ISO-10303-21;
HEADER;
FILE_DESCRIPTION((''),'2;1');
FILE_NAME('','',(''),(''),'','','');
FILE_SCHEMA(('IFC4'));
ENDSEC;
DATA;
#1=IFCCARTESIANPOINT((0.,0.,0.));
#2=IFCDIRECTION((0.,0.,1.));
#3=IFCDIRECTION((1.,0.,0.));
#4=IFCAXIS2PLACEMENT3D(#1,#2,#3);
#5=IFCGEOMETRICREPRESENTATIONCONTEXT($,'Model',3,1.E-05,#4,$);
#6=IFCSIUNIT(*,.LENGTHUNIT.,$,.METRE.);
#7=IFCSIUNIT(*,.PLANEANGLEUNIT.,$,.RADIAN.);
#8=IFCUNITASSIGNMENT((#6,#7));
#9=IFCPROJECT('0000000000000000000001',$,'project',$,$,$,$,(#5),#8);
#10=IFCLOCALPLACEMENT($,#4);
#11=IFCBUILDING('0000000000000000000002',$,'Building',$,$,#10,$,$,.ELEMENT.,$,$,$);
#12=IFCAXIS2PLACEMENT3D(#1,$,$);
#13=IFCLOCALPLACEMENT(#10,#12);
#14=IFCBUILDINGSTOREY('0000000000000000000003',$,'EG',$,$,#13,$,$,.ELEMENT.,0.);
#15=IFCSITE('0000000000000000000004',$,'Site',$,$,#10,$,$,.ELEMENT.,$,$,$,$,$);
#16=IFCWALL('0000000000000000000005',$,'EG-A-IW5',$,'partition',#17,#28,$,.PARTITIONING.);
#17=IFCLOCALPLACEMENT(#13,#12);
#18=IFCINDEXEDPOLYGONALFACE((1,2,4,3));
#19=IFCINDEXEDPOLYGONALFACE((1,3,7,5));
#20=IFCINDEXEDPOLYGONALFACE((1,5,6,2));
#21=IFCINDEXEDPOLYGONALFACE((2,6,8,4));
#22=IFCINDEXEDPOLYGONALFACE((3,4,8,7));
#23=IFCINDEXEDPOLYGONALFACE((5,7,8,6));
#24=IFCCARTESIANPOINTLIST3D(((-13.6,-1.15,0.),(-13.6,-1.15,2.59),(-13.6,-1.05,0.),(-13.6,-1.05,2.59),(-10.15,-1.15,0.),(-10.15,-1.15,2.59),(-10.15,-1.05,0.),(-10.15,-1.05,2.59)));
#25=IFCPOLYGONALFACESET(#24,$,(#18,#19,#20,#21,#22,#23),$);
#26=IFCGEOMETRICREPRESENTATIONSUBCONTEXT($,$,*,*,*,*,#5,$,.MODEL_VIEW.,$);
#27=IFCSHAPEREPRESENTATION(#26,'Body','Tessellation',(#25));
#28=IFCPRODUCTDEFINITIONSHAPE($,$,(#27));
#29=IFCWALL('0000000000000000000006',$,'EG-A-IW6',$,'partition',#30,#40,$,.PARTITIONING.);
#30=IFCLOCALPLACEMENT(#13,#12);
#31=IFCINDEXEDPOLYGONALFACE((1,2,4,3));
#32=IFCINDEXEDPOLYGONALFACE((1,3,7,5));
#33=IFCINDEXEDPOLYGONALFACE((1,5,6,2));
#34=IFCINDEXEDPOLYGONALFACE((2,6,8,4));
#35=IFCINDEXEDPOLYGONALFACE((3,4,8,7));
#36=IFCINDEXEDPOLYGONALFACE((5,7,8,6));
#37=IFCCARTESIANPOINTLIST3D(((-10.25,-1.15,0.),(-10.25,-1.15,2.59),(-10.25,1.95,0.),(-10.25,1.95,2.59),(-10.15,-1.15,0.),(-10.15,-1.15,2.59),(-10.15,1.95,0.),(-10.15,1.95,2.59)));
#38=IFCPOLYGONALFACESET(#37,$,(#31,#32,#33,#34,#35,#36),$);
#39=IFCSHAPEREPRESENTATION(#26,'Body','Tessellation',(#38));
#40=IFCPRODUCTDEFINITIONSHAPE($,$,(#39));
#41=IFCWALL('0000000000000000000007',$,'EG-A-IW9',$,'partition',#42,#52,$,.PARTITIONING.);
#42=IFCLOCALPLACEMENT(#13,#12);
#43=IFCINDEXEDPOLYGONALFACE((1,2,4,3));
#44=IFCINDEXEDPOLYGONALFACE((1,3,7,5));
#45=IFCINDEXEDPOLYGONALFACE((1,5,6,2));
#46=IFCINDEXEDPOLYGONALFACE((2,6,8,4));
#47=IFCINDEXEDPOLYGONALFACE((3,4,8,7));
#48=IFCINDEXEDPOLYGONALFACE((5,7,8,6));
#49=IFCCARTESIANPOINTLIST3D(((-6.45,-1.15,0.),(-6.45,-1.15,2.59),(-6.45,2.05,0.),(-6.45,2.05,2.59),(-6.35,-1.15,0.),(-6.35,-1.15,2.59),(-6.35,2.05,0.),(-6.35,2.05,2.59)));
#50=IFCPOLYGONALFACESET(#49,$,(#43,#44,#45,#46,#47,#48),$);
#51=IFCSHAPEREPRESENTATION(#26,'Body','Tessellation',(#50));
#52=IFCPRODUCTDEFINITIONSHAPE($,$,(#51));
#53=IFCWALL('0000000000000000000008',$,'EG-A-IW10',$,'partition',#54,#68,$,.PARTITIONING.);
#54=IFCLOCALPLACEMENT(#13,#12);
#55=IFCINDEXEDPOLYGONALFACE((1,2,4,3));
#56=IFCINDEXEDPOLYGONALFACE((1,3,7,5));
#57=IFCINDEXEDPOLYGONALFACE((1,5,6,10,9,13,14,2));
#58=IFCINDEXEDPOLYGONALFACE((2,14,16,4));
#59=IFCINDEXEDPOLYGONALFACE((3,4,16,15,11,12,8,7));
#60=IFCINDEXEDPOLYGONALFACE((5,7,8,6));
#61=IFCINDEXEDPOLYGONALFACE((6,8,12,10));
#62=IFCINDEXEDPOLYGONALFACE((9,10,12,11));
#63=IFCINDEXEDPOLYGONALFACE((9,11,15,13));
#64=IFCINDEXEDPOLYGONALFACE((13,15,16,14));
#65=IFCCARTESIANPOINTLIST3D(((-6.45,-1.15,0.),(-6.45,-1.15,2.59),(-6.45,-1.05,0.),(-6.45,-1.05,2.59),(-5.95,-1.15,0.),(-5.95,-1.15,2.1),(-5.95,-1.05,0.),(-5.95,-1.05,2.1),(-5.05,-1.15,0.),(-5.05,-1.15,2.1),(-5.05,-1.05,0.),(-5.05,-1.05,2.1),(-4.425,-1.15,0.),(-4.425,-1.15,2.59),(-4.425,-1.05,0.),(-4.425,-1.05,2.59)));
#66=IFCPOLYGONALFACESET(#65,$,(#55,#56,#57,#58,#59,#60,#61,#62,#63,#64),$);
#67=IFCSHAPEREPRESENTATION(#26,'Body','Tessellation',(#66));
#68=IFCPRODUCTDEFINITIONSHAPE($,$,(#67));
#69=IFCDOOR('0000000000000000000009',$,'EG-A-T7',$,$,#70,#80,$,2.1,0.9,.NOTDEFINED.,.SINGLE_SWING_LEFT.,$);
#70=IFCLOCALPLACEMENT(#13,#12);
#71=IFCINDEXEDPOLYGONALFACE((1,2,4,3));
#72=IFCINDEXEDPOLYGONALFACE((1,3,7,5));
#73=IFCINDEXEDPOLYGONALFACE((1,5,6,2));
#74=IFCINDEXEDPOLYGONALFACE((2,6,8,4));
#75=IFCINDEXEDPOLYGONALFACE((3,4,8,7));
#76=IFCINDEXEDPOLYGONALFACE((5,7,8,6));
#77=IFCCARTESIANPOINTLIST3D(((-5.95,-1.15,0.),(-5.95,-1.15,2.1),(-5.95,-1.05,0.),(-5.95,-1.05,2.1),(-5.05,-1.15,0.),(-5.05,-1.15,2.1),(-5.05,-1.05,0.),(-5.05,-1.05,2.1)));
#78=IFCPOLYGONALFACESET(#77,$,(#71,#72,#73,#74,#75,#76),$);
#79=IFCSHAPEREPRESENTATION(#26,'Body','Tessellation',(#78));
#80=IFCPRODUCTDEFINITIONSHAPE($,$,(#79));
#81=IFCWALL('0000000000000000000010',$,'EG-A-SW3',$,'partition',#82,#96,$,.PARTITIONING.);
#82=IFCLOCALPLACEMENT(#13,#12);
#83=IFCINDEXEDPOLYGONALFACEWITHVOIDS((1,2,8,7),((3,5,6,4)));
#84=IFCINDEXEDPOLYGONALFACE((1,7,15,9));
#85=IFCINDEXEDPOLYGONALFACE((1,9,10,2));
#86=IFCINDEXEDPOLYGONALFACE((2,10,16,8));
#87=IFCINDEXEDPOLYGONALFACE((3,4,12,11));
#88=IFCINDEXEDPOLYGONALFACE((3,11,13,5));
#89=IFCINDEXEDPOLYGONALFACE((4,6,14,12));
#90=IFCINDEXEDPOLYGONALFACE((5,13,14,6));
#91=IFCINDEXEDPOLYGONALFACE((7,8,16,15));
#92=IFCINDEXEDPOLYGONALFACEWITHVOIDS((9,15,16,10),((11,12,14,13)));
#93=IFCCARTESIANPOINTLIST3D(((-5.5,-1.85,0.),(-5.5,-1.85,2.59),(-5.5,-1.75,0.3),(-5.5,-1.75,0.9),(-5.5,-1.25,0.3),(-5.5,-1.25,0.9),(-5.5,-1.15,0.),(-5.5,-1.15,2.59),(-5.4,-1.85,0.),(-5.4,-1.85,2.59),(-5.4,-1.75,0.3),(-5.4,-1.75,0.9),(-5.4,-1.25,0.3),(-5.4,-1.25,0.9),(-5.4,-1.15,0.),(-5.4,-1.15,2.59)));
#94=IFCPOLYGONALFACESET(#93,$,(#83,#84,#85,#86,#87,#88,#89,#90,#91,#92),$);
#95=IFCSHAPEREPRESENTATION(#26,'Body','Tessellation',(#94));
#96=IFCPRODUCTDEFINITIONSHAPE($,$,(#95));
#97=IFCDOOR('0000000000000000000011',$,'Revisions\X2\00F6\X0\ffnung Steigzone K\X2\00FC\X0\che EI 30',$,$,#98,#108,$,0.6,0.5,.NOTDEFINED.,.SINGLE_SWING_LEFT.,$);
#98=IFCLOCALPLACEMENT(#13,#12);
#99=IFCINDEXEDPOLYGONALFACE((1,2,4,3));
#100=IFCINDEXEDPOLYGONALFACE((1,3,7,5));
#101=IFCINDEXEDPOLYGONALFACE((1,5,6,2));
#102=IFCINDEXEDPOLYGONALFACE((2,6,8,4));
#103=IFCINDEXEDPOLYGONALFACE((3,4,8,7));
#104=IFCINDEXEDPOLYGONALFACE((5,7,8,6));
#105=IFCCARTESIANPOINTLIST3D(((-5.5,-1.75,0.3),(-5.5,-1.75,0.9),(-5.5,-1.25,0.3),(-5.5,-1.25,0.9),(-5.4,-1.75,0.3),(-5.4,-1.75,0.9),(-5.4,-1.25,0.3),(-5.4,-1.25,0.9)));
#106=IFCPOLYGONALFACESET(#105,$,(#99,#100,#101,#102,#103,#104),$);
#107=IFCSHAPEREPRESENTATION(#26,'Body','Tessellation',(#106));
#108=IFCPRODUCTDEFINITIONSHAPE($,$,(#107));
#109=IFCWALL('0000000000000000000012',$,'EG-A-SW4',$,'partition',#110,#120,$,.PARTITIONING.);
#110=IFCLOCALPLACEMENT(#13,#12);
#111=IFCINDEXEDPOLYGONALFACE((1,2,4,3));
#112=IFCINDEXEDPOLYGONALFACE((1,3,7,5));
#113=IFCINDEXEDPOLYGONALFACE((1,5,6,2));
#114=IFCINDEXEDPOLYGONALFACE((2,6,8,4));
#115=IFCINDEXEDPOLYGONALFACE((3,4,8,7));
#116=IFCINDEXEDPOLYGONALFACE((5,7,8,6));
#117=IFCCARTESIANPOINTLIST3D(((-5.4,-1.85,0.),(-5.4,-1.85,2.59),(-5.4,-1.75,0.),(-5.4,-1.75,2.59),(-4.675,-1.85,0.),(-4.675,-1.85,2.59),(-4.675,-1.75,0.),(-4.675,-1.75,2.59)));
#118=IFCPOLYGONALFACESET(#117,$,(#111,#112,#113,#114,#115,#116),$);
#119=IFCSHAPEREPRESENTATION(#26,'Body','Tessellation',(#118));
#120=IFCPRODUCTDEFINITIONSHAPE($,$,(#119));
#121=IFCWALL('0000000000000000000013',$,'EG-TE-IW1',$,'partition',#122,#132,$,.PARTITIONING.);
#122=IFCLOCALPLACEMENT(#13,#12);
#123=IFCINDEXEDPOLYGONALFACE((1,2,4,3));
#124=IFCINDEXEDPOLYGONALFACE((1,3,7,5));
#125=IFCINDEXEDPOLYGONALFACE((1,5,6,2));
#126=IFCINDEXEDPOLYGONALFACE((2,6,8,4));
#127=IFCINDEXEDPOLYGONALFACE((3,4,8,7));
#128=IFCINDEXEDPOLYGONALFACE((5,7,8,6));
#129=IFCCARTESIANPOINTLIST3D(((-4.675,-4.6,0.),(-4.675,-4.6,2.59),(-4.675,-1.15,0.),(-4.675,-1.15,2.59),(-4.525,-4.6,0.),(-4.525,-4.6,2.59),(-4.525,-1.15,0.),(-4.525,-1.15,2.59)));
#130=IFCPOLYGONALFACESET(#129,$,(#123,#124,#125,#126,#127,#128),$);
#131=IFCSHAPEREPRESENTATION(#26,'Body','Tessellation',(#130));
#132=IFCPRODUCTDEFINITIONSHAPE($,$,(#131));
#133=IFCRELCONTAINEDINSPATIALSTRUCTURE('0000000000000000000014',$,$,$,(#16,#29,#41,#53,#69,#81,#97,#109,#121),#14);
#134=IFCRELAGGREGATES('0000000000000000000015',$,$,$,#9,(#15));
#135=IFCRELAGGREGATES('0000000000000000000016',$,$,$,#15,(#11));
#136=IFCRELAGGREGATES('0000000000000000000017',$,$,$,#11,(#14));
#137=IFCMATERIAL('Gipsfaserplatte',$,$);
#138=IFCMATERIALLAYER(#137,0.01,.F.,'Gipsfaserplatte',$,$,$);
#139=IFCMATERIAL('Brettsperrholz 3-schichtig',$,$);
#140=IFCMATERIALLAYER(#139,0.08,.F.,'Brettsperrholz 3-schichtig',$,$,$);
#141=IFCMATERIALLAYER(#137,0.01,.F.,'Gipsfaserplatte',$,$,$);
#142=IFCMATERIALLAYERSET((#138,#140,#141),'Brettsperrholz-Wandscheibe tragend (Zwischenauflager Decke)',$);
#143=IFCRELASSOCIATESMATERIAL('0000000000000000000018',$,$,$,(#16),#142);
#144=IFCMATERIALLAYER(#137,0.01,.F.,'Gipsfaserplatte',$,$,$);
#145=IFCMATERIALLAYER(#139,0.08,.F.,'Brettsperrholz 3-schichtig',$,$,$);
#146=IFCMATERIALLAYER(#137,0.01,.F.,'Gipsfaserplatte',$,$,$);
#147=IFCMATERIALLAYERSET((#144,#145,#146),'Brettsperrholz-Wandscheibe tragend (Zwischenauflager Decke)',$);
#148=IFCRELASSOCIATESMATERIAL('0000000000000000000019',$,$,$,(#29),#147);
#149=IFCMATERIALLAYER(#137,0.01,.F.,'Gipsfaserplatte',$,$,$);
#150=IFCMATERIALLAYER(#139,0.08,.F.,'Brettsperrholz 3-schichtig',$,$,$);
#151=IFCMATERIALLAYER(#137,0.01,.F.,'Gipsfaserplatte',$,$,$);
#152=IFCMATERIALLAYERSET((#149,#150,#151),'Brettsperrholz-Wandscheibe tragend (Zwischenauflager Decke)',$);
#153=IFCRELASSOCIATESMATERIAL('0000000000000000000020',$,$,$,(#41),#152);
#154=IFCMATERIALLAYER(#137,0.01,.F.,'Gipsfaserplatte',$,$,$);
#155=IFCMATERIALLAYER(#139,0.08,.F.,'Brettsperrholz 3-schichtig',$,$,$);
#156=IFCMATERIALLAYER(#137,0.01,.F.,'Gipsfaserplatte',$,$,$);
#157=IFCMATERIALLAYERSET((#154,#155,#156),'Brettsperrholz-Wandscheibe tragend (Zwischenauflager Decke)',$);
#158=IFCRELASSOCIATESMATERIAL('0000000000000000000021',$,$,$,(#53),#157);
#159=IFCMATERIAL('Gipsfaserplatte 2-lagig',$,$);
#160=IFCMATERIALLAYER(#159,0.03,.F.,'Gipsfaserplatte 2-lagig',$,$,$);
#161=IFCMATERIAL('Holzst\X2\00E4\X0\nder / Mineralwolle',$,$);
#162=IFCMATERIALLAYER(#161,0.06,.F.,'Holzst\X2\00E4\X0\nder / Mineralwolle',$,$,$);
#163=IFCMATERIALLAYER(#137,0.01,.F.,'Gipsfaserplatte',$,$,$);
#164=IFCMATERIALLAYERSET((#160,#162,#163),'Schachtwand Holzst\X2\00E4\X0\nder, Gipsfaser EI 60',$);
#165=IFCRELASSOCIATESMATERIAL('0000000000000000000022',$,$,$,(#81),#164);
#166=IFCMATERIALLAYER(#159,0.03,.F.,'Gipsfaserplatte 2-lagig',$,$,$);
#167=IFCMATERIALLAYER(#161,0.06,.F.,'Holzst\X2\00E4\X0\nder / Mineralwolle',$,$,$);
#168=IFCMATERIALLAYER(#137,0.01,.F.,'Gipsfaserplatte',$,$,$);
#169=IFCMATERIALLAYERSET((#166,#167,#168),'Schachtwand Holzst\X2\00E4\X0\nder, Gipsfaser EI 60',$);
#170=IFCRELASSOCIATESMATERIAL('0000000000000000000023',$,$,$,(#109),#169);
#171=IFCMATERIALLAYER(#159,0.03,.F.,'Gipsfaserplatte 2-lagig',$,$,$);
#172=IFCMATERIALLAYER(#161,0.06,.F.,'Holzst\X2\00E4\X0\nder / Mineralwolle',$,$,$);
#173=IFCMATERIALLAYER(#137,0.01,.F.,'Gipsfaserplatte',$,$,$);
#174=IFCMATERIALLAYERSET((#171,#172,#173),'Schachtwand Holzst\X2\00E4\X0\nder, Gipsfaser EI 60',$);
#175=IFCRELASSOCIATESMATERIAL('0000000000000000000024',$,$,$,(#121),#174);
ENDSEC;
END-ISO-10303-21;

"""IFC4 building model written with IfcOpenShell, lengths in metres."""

from ifc_helpers import new_model, si_unit, frame, frame_2d, origin, origin_with_axes, place, context, subcontext, project, spatial, rectangle, extrude, material, layer, layer_set, element, fill, save


model = new_model("IFC4")

# Units and contexts
model_context = context("Model", 3, precision=1e-05, world=origin_with_axes())
sub_context = subcontext(model_context, None, None, "MODEL_VIEW")
ifc_project = project(units=[si_unit("LENGTHUNIT", "METRE"), si_unit("PLANEANGLEUNIT", "RADIAN")], contexts=[model_context])

# Site, building, storey
placement = place(None, origin_with_axes())
site = spatial("IfcSite", under=ifc_project, at=placement, Name="Site", CompositionType="ELEMENT")
building = spatial("IfcBuilding", under=site, at=placement, Name="Building", CompositionType="ELEMENT")
storey_placement = place(placement, origin())
storey = spatial("IfcBuildingStorey", under=building, at=storey_placement, Name="EG", CompositionType="ELEMENT", Elevation=0.0)

# Shared definitions
ifc_material_1 = material(Name="Gipsfaserplatte")

# Walls
ifc_layer_1 = layer(ifc_material_1, 0.01, ventilated=False, Name="Gipsfaserplatte")
ifc_material_2 = material(Name="Brettsperrholz 3-schichtig")
ifc_layer_2 = layer(ifc_material_2, 0.08, ventilated=False, Name="Brettsperrholz 3-schichtig")
ifc_layer_3 = layer(ifc_material_1, 0.01, ventilated=False, Name="Gipsfaserplatte")
ifc_layer_set_1 = layer_set([ifc_layer_1, ifc_layer_2, ifc_layer_3], Name="Brettsperrholz-Wandscheibe tragend (Zwischenauflager Decke)")
wall_1_placement = place(storey_placement, frame((-13.6, -1.1, 0.0), z_axis=(0.0, 0.0, 1.0), x_axis=(1.0, 0.0, 0.0)))
element("IfcWall", 1, at=wall_1_placement, inside=storey, material=ifc_layer_set_1, Name="EG-A-IW5", ObjectType="partition", PredefinedType="PARTITIONING", context=sub_context, shape_type="SweptSolid", body=[
    extrude(rectangle(XDim=3.45, YDim=0.1, at=frame_2d((1.725, 0.0))), origin(), (0.0, 0.0, 1.0), 2.59),
])
ifc_layer_4 = layer(ifc_material_1, 0.01, ventilated=False, Name="Gipsfaserplatte")
ifc_layer_5 = layer(ifc_material_2, 0.08, ventilated=False, Name="Brettsperrholz 3-schichtig")
ifc_layer_6 = layer(ifc_material_1, 0.01, ventilated=False, Name="Gipsfaserplatte")
ifc_layer_set_2 = layer_set([ifc_layer_4, ifc_layer_5, ifc_layer_6], Name="Brettsperrholz-Wandscheibe tragend (Zwischenauflager Decke)")
wall_2_placement = place(storey_placement, frame((-10.2, -1.15, 0.0), z_axis=(0.0, 0.0, 1.0), x_axis=(0.0, 1.0, 0.0)))
element("IfcWall", 2, at=wall_2_placement, inside=storey, material=ifc_layer_set_2, Name="EG-A-IW6", ObjectType="partition", PredefinedType="PARTITIONING", context=sub_context, shape_type="SweptSolid", body=[
    extrude(rectangle(XDim=3.1, YDim=0.1, at=frame_2d((1.55, 0.0))), origin(), (0.0, 0.0, 1.0), 2.59),
])
ifc_layer_7 = layer(ifc_material_1, 0.01, ventilated=False, Name="Gipsfaserplatte")
ifc_layer_8 = layer(ifc_material_2, 0.08, ventilated=False, Name="Brettsperrholz 3-schichtig")
ifc_layer_9 = layer(ifc_material_1, 0.01, ventilated=False, Name="Gipsfaserplatte")
ifc_layer_set_3 = layer_set([ifc_layer_7, ifc_layer_8, ifc_layer_9], Name="Brettsperrholz-Wandscheibe tragend (Zwischenauflager Decke)")
wall_3_placement = place(storey_placement, frame((-6.4, -1.15, 0.0), z_axis=(0.0, 0.0, 1.0), x_axis=(0.0, 1.0, 0.0)))
element("IfcWall", 3, at=wall_3_placement, inside=storey, material=ifc_layer_set_3, Name="EG-A-IW9", ObjectType="partition", PredefinedType="PARTITIONING", context=sub_context, shape_type="SweptSolid", body=[
    extrude(rectangle(XDim=3.2, YDim=0.1, at=frame_2d((1.6, 0.0))), origin(), (0.0, 0.0, 1.0), 2.59),
])

# Walls, openings, doors
ifc_layer_10 = layer(ifc_material_1, 0.01, ventilated=False, Name="Gipsfaserplatte")
ifc_layer_11 = layer(ifc_material_2, 0.08, ventilated=False, Name="Brettsperrholz 3-schichtig")
ifc_layer_12 = layer(ifc_material_1, 0.01, ventilated=False, Name="Gipsfaserplatte")
ifc_layer_set_4 = layer_set([ifc_layer_10, ifc_layer_11, ifc_layer_12], Name="Brettsperrholz-Wandscheibe tragend (Zwischenauflager Decke)")
wall_4_placement = place(storey_placement, frame((-6.45, -1.1, 0.0), z_axis=(0.0, 0.0, 1.0), x_axis=(1.0, 0.0, 0.0)))
wall_4 = element("IfcWall", 4, at=wall_4_placement, inside=storey, material=ifc_layer_set_4, Name="EG-A-IW10", ObjectType="partition", PredefinedType="PARTITIONING", context=sub_context, shape_type="SweptSolid", body=[
    extrude(rectangle(XDim=2.025, YDim=0.1, at=frame_2d((1.0125, 0.0))), origin(), (0.0, 0.0, 1.0), 2.59),
])
opening_1_placement = place(wall_4_placement, frame((0.95, 0.1, 0.0), z_axis=(0.0, -1.0, 0.0), x_axis=(1.0, 0.0, 0.0)))
opening_1 = element("IfcOpeningElement", 5, at=opening_1_placement, cuts=wall_4, PredefinedType="OPENING", context=sub_context, shape_type="SweptSolid", body=[
    extrude(rectangle(XDim=0.9, YDim=2.1, at=frame_2d((0.0, 1.05))), origin(), (0.0, 0.0, 1.0), 0.2),
])
door_1_placement = place(wall_4_placement, frame((0.95, 0.05, 0.0), z_axis=(0.0, -1.0, 0.0), x_axis=(1.0, 0.0, 0.0)))
door_1 = element("IfcDoor", 6, at=door_1_placement, inside=storey, Name="EG-A-T7", OperationType="SINGLE_SWING_LEFT", OverallHeight=2.1, OverallWidth=0.9, PredefinedType="NOTDEFINED", context=sub_context, shape_type="SweptSolid", body=[
    extrude(rectangle(XDim=0.9, YDim=2.1, at=frame_2d((0.0, 1.05))), origin(), (0.0, 0.0, 1.0), 0.1),
])
fill(opening_1, door_1)
ifc_material_3 = material(Name="Gipsfaserplatte 2-lagig")
ifc_layer_13 = layer(ifc_material_3, 0.03, ventilated=False, Name="Gipsfaserplatte 2-lagig")
ifc_material_4 = material(Name="Holzständer / Mineralwolle")
ifc_layer_14 = layer(ifc_material_4, 0.06, ventilated=False, Name="Holzständer / Mineralwolle")
ifc_layer_15 = layer(ifc_material_1, 0.01, ventilated=False, Name="Gipsfaserplatte")
ifc_layer_set_5 = layer_set([ifc_layer_13, ifc_layer_14, ifc_layer_15], Name="Schachtwand Holzständer, Gipsfaser EI 60")
wall_5_placement = place(storey_placement, frame((-5.45, -1.85, 0.0), z_axis=(0.0, 0.0, 1.0), x_axis=(0.0, 1.0, 0.0)))
wall_5 = element("IfcWall", 7, at=wall_5_placement, inside=storey, material=ifc_layer_set_5, Name="EG-A-SW3", ObjectType="partition", PredefinedType="PARTITIONING", context=sub_context, shape_type="SweptSolid", body=[
    extrude(rectangle(XDim=0.7, YDim=0.1, at=frame_2d((0.35, 0.0))), origin(), (0.0, 0.0, 1.0), 2.59),
])
opening_2_placement = place(wall_5_placement, frame((0.35, 0.1, 0.3), z_axis=(0.0, -1.0, 0.0), x_axis=(1.0, 0.0, 0.0)))
opening_2 = element("IfcOpeningElement", 8, at=opening_2_placement, cuts=wall_5, PredefinedType="OPENING", context=sub_context, shape_type="SweptSolid", body=[
    extrude(rectangle(XDim=0.5, YDim=0.6, at=frame_2d((0.0, 0.3))), origin(), (0.0, 0.0, 1.0), 0.2),
])
door_2_placement = place(wall_5_placement, frame((0.35, 0.05, 0.3), z_axis=(0.0, -1.0, 0.0), x_axis=(1.0, 0.0, 0.0)))
door_2 = element("IfcDoor", 9, at=door_2_placement, inside=storey, Name="Revisionsöffnung Steigzone Küche EI 30", OperationType="SINGLE_SWING_LEFT", OverallHeight=0.6, OverallWidth=0.5, PredefinedType="NOTDEFINED", context=sub_context, shape_type="SweptSolid", body=[
    extrude(rectangle(XDim=0.5, YDim=0.6, at=frame_2d((0.0, 0.3))), origin(), (0.0, 0.0, 1.0), 0.1),
])
fill(opening_2, door_2)

# Walls
ifc_layer_16 = layer(ifc_material_3, 0.03, ventilated=False, Name="Gipsfaserplatte 2-lagig")
ifc_layer_17 = layer(ifc_material_4, 0.06, ventilated=False, Name="Holzständer / Mineralwolle")
ifc_layer_18 = layer(ifc_material_1, 0.01, ventilated=False, Name="Gipsfaserplatte")
ifc_layer_set_6 = layer_set([ifc_layer_16, ifc_layer_17, ifc_layer_18], Name="Schachtwand Holzständer, Gipsfaser EI 60")
wall_6_placement = place(storey_placement, frame((-5.4, -1.8, 0.0), z_axis=(0.0, 0.0, 1.0), x_axis=(1.0, 0.0, 0.0)))
element("IfcWall", 10, at=wall_6_placement, inside=storey, material=ifc_layer_set_6, Name="EG-A-SW4", ObjectType="partition", PredefinedType="PARTITIONING", context=sub_context, shape_type="SweptSolid", body=[
    extrude(rectangle(XDim=0.725, YDim=0.1, at=frame_2d((0.3625, 0.0))), origin(), (0.0, 0.0, 1.0), 2.59),
])
ifc_layer_19 = layer(ifc_material_3, 0.03, ventilated=False, Name="Gipsfaserplatte 2-lagig")
ifc_layer_20 = layer(ifc_material_4, 0.06, ventilated=False, Name="Holzständer / Mineralwolle")
ifc_layer_21 = layer(ifc_material_1, 0.01, ventilated=False, Name="Gipsfaserplatte")
ifc_layer_set_7 = layer_set([ifc_layer_19, ifc_layer_20, ifc_layer_21], Name="Schachtwand Holzständer, Gipsfaser EI 60")
wall_7_placement = place(storey_placement, frame((-4.6, -4.6, 0.0), z_axis=(0.0, 0.0, 1.0), x_axis=(0.0, 1.0, 0.0)))
element("IfcWall", 11, at=wall_7_placement, inside=storey, material=ifc_layer_set_7, Name="EG-TE-IW1", ObjectType="partition", PredefinedType="PARTITIONING", context=sub_context, shape_type="SweptSolid", body=[
    extrude(rectangle(XDim=3.45, YDim=0.15, at=frame_2d((1.725, 0.0))), origin(), (0.0, 0.0, 1.0), 2.59),
])

save(model, "model.ifc")
